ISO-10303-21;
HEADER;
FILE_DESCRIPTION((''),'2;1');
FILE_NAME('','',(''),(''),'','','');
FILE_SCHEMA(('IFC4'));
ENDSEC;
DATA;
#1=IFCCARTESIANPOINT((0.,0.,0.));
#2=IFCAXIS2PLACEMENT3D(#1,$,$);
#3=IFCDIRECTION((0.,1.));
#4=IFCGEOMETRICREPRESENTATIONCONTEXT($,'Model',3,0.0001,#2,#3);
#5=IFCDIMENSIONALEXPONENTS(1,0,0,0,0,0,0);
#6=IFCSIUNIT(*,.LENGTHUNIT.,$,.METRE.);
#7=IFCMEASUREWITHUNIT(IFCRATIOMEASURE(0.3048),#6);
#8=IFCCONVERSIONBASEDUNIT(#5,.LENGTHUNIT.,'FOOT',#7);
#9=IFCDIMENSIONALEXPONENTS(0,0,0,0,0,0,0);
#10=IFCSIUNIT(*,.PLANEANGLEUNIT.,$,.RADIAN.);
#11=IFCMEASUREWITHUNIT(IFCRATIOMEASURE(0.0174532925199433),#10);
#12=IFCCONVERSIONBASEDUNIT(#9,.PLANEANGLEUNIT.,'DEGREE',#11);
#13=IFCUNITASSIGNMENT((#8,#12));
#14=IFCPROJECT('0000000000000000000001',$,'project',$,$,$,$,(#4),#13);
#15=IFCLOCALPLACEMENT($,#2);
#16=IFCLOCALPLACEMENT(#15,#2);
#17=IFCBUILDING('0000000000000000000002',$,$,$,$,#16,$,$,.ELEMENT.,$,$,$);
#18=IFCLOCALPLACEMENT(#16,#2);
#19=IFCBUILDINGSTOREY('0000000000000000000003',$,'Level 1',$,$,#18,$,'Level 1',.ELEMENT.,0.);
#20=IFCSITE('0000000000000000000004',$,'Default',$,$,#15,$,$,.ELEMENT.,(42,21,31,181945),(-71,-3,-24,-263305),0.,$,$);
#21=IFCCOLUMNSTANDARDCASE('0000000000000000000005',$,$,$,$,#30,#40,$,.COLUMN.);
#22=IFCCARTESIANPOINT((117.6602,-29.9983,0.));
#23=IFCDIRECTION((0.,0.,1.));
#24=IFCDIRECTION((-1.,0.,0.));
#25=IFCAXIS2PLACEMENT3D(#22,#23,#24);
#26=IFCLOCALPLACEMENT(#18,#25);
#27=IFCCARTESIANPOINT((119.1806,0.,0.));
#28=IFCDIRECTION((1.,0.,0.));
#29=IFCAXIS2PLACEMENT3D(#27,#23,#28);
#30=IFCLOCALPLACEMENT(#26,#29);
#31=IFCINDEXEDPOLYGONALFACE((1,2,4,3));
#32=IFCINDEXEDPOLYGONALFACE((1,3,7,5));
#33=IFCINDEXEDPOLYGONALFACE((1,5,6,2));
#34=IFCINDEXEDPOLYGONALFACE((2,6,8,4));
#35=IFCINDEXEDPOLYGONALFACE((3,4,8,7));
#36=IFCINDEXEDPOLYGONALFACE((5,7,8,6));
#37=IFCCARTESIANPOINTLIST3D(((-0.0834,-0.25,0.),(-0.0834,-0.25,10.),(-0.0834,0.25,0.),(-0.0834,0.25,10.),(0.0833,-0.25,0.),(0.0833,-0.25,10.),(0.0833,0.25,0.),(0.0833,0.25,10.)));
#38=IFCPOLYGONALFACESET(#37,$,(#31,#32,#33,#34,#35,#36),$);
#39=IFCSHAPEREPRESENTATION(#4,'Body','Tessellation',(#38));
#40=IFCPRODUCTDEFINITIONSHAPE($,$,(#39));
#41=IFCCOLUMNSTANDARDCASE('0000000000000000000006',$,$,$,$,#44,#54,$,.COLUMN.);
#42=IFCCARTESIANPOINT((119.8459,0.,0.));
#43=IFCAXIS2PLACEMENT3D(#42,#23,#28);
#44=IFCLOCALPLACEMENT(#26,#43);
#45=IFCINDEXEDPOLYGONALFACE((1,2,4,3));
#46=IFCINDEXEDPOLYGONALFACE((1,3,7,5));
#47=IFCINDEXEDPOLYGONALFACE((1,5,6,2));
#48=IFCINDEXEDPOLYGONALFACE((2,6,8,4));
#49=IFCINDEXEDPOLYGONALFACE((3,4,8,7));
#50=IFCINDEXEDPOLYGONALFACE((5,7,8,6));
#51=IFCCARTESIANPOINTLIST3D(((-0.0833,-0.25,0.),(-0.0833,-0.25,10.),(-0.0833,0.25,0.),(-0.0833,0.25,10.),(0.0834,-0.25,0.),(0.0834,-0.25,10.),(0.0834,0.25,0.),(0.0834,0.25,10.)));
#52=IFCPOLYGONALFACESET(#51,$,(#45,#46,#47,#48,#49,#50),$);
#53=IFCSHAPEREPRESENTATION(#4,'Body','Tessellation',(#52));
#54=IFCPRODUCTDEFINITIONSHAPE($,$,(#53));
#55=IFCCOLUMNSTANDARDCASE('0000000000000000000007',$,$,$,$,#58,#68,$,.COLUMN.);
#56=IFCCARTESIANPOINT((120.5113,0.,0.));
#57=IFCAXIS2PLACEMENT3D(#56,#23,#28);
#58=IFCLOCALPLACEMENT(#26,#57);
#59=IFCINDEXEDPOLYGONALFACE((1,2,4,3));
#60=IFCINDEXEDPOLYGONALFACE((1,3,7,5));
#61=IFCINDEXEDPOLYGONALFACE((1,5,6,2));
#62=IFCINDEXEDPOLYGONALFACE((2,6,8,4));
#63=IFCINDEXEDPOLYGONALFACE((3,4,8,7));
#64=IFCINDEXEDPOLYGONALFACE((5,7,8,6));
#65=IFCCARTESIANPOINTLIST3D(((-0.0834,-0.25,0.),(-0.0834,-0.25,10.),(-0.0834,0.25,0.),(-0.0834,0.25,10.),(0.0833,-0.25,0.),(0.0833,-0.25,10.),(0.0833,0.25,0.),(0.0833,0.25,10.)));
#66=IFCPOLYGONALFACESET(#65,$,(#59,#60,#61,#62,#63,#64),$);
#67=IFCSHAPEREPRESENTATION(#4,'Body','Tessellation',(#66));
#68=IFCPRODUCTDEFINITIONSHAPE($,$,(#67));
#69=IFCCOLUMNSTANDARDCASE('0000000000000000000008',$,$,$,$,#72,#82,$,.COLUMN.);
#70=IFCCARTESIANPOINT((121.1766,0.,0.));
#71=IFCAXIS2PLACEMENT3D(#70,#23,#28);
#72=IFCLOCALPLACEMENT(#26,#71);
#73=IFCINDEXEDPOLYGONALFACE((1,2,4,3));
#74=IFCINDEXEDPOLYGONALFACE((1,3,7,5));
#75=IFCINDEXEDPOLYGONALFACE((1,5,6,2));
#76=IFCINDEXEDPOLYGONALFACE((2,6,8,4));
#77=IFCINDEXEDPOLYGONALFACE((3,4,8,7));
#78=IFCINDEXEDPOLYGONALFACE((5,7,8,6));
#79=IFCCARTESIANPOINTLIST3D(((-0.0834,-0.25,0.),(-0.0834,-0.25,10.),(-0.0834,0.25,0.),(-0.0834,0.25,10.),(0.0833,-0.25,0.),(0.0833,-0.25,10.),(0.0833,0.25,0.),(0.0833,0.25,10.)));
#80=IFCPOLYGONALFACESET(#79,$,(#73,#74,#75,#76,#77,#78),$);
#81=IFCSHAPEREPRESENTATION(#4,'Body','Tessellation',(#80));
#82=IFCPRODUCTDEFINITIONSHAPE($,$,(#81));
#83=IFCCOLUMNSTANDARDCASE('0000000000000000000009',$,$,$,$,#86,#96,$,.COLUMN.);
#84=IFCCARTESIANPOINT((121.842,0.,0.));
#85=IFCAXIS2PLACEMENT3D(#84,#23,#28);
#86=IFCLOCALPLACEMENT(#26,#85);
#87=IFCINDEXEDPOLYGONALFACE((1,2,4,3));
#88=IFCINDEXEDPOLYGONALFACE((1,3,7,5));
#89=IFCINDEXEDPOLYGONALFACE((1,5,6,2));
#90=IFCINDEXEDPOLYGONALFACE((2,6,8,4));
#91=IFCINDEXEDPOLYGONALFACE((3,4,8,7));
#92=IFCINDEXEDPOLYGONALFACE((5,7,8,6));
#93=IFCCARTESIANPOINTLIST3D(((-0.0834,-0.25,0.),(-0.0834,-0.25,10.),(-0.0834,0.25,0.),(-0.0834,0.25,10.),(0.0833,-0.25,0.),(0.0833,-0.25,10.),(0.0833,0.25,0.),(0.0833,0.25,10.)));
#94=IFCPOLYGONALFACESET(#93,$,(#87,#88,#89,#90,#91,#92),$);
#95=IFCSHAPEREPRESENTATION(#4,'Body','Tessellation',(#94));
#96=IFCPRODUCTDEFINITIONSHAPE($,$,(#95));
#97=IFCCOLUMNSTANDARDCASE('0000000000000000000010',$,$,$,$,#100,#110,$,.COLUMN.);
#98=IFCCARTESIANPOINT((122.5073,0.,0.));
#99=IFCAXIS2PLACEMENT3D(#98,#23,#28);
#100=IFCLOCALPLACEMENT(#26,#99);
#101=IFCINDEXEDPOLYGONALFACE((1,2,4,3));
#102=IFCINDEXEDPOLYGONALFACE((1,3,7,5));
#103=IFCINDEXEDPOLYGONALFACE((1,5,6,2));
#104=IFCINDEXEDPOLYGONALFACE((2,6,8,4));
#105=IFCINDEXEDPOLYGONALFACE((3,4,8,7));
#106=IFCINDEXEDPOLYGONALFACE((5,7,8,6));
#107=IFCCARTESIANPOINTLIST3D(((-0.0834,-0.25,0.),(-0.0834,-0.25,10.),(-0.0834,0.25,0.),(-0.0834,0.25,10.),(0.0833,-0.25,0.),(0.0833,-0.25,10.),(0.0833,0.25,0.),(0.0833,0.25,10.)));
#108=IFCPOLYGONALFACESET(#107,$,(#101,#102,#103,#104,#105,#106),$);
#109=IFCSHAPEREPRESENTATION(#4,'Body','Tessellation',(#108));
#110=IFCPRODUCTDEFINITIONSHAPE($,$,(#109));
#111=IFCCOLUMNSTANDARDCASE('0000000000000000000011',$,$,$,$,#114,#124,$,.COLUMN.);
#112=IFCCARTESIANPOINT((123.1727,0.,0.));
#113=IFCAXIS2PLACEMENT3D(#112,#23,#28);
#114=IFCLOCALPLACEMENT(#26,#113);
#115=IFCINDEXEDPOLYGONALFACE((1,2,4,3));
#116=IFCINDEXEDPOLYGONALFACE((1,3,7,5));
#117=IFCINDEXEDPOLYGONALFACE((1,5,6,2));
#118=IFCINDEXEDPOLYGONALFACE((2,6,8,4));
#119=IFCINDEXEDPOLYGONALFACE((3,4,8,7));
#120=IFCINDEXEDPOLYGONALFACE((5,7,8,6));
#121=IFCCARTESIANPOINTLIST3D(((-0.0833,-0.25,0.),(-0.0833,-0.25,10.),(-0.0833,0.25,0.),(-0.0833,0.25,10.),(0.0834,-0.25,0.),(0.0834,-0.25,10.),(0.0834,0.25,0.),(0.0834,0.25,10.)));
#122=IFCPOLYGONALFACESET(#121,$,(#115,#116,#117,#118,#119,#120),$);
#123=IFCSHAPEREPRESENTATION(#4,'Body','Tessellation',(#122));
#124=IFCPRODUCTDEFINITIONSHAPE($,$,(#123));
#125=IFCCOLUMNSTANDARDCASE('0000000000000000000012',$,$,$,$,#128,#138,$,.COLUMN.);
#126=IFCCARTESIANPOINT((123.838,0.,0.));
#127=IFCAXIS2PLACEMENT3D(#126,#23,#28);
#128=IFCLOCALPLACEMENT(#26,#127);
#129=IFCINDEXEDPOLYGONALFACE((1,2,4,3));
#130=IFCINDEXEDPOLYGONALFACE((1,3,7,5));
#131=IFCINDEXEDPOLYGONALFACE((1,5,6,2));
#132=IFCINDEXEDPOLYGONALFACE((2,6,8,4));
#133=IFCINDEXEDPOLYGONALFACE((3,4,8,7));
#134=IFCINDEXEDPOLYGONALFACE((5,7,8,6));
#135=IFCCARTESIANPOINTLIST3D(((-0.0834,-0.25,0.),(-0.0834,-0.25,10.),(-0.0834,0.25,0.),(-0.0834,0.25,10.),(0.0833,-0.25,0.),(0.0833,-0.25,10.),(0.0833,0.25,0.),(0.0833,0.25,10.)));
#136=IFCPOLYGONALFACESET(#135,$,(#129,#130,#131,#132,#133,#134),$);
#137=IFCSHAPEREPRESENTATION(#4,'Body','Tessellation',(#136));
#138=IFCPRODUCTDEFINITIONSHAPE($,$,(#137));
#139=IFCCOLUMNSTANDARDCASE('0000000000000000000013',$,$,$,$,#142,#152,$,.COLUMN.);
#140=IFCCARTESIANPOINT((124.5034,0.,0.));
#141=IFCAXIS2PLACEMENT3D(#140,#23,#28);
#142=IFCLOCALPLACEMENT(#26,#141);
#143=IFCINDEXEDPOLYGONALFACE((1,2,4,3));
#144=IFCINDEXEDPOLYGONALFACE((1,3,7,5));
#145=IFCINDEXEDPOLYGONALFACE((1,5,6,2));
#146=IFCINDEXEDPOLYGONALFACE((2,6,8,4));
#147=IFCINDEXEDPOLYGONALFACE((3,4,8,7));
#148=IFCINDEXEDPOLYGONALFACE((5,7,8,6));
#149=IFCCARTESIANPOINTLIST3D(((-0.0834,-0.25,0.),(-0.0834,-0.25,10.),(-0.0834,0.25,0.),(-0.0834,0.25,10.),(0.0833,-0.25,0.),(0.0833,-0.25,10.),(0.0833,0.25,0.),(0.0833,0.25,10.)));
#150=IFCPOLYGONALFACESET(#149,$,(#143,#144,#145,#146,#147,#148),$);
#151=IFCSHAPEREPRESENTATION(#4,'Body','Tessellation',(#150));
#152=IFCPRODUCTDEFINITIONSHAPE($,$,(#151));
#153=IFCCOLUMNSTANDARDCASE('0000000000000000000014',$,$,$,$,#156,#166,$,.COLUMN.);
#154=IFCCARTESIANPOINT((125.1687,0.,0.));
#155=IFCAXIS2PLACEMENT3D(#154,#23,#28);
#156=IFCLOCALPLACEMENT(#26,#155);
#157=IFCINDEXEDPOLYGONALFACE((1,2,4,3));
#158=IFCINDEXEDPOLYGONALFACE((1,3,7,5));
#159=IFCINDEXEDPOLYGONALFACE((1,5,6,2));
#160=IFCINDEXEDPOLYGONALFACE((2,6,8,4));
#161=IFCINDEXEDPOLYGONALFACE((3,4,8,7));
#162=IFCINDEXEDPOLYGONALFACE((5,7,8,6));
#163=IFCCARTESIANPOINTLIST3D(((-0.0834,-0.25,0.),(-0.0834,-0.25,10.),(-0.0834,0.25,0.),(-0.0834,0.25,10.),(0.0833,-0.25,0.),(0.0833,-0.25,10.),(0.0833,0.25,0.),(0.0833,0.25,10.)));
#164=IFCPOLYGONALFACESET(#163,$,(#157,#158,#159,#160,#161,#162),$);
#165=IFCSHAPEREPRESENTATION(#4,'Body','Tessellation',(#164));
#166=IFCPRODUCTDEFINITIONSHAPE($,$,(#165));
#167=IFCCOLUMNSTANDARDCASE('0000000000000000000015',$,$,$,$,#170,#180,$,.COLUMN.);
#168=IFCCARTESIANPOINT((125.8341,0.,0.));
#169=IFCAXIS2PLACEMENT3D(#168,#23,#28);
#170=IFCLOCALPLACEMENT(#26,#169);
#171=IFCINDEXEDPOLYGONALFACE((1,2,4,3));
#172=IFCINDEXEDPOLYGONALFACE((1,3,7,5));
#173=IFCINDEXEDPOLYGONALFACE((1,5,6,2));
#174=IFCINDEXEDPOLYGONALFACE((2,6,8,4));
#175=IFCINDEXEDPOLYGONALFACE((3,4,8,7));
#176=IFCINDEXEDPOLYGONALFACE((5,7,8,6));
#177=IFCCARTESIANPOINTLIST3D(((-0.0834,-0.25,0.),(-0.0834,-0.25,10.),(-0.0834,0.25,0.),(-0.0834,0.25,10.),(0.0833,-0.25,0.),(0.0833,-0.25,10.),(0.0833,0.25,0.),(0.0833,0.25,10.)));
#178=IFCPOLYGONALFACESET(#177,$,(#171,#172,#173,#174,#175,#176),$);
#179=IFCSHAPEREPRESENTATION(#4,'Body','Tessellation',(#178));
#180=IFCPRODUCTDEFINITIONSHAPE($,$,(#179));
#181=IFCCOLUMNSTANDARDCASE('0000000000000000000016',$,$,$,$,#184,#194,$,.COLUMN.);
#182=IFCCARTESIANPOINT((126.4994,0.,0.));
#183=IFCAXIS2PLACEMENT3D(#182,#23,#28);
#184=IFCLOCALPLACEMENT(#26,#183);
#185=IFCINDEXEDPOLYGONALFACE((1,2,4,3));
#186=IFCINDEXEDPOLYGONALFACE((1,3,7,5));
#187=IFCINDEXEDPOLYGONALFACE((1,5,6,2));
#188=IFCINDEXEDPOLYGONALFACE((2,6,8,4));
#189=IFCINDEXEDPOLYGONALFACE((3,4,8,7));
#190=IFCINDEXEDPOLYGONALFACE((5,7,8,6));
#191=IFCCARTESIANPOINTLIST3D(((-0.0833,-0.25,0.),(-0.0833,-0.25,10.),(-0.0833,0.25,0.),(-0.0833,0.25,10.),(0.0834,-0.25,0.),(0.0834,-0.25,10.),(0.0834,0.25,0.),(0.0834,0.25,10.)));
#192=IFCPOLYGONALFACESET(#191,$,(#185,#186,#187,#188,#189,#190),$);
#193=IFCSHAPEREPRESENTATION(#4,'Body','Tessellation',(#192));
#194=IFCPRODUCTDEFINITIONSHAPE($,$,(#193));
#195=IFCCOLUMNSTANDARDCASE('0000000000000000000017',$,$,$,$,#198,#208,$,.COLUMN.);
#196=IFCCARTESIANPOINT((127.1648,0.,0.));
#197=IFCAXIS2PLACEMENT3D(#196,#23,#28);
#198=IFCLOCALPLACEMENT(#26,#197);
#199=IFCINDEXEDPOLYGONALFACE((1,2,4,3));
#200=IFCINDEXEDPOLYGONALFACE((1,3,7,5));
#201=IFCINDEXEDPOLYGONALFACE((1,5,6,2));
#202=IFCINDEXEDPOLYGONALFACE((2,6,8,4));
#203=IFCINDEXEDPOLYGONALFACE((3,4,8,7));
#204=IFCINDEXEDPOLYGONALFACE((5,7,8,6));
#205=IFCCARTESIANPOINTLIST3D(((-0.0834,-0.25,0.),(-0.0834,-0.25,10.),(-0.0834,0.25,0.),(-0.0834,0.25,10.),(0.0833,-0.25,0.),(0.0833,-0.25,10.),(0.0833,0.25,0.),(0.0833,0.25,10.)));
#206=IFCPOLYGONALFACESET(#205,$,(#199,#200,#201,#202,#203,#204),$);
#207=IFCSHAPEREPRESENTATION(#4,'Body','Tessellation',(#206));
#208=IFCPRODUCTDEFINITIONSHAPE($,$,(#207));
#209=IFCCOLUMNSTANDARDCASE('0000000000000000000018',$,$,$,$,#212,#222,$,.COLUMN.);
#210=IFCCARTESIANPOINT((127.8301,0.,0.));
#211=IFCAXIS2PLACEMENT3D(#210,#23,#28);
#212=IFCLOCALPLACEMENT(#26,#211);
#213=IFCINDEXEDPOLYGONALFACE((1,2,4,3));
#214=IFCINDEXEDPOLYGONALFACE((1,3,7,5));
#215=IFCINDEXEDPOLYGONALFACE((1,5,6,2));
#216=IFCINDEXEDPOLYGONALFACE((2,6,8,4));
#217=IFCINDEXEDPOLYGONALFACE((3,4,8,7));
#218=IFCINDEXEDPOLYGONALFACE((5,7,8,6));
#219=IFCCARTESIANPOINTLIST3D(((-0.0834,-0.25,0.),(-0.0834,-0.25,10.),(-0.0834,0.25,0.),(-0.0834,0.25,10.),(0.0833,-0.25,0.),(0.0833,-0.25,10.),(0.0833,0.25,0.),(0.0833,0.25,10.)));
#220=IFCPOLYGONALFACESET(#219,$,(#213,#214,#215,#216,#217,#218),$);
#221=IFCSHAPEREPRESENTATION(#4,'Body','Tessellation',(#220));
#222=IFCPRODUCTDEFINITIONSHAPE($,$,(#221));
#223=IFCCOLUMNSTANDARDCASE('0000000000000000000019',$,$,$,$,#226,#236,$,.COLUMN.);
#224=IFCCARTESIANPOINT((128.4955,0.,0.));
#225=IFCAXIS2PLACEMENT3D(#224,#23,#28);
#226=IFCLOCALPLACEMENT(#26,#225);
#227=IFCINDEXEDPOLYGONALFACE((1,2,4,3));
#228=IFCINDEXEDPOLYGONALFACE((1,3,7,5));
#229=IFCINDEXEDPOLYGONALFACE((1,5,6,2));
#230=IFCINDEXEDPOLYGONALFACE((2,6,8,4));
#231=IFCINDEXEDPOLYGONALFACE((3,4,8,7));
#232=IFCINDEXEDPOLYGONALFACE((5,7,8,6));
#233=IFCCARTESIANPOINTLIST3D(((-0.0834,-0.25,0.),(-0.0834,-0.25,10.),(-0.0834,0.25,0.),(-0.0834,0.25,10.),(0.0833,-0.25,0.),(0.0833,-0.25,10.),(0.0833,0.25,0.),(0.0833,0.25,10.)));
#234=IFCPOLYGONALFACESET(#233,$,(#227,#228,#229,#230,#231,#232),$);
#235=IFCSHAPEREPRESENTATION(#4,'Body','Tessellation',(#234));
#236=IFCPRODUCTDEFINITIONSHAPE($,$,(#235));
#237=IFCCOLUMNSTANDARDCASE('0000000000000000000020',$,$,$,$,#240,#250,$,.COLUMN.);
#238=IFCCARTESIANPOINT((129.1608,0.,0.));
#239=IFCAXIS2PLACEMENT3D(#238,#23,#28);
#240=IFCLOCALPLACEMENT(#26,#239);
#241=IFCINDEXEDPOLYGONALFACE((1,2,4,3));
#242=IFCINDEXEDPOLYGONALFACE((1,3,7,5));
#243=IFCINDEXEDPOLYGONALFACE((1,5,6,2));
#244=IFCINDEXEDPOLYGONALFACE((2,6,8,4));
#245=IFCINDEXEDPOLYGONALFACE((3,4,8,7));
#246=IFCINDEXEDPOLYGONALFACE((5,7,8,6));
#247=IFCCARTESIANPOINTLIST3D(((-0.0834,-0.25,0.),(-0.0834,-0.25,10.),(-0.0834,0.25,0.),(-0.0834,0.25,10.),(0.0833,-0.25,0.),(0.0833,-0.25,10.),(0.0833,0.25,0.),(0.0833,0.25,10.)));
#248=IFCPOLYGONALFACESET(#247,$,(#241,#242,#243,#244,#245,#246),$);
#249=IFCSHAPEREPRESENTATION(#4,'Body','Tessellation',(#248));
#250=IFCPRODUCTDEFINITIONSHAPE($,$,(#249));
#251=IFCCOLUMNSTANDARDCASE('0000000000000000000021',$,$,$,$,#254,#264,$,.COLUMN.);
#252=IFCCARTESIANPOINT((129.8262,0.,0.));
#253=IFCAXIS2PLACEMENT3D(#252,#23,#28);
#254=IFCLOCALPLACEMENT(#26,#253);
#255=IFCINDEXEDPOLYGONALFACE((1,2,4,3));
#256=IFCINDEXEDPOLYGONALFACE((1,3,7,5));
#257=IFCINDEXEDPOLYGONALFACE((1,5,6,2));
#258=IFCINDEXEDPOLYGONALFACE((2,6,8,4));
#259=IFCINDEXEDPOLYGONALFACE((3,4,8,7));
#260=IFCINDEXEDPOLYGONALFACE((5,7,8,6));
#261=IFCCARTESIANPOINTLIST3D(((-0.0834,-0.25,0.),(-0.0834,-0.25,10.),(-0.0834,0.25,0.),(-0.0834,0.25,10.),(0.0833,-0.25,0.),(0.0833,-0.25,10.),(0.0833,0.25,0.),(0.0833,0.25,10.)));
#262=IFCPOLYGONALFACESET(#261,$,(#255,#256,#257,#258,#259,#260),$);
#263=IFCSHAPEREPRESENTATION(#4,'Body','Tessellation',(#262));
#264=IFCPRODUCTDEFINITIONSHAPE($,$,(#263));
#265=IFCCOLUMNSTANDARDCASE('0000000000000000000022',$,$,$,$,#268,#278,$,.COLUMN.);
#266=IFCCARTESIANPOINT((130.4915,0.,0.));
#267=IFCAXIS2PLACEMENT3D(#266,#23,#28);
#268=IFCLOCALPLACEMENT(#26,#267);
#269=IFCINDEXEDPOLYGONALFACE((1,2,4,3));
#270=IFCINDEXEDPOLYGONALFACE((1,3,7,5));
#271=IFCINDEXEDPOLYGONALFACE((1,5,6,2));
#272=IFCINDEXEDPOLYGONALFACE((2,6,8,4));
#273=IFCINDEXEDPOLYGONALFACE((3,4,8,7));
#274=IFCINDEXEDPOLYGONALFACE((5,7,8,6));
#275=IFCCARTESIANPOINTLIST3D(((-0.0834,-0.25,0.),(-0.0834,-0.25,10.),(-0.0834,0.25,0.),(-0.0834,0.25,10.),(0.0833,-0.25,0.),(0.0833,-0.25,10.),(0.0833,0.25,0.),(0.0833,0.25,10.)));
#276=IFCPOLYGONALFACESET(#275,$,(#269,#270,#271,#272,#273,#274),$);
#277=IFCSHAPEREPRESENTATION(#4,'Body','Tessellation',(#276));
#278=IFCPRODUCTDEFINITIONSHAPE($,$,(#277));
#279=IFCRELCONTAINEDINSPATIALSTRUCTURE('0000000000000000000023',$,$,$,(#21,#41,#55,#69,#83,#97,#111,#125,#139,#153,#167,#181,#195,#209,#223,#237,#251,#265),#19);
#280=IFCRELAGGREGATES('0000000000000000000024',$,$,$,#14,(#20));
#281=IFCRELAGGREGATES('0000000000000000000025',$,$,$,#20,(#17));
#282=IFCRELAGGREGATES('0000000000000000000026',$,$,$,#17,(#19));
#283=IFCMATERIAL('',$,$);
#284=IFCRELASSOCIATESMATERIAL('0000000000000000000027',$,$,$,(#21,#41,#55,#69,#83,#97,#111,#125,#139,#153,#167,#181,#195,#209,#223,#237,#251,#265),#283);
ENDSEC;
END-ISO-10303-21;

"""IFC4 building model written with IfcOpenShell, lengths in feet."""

from ifc_helpers import new_model, entity, si_unit, converted_unit, direction, frame, origin, place, context, project, spatial, rectangle, extrude, material, element, save


model = new_model("IFC4")

# Units and contexts
model_context = context("Model", 3, precision=0.0001, world=origin(), true_north=direction((0.0, 1.0)))
ifc_project = project(units=[converted_unit("LENGTHUNIT", "FOOT", entity("IfcRatioMeasure", 0.3048), si_unit("LENGTHUNIT", "METRE"), dimensions=[1, 0, 0, 0, 0, 0, 0]), converted_unit("PLANEANGLEUNIT", "DEGREE", entity("IfcRatioMeasure", 0.0174532925199433), si_unit("PLANEANGLEUNIT", "RADIAN"), dimensions=[0, 0, 0, 0, 0, 0, 0])], contexts=[model_context])

# Site, building, storey
site_placement = place(None, origin())
site = spatial("IfcSite", under=ifc_project, at=site_placement, Name="Default", CompositionType="ELEMENT", RefLatitude=(42, 21, 31, 181945), RefLongitude=(-71, -3, -24, -263305), RefElevation=0.0)
building_placement = place(site_placement, origin())
building = spatial("IfcBuilding", under=site, at=building_placement, CompositionType="ELEMENT")
storey_placement = place(building_placement, origin())
storey = spatial("IfcBuildingStorey", under=building, at=storey_placement, Name="Level 1", LongName="Level 1", CompositionType="ELEMENT", Elevation=0.0)

# Columns
ifc_material = material(Name="")
placement = place(storey_placement, frame((117.6602, -29.9983, 0.0), z_axis=(0.0, 0.0, 1.0), x_axis=(-1.0, 0.0, 0.0)))
for number, where, z_axis, x_axis in (
    (1, (119.1806, 0.0, 0.0), (0.0, 0.0, 1.0), (1.0, 0.0, 0.0)),
    (2, (119.8459, 0.0, 0.0), (0.0, 0.0, 1.0), (1.0, 0.0, 0.0)),
    (3, (120.5113, 0.0, 0.0), (0.0, 0.0, 1.0), (1.0, 0.0, 0.0)),
    (4, (121.1766, 0.0, 0.0), (0.0, 0.0, 1.0), (1.0, 0.0, 0.0)),
    (5, (121.842, 0.0, 0.0), (0.0, 0.0, 1.0), (1.0, 0.0, 0.0)),
    (6, (122.5073, 0.0, 0.0), (0.0, 0.0, 1.0), (1.0, 0.0, 0.0)),
    (7, (123.1727, 0.0, 0.0), (0.0, 0.0, 1.0), (1.0, 0.0, 0.0)),
    (8, (123.838, 0.0, 0.0), (0.0, 0.0, 1.0), (1.0, 0.0, 0.0)),
    (9, (124.5034, 0.0, 0.0), (0.0, 0.0, 1.0), (1.0, 0.0, 0.0)),
    (10, (125.1687, 0.0, 0.0), (0.0, 0.0, 1.0), (1.0, 0.0, 0.0)),
    (11, (125.8341, 0.0, 0.0), (0.0, 0.0, 1.0), (1.0, 0.0, 0.0)),
    (12, (126.4994, 0.0, 0.0), (0.0, 0.0, 1.0), (1.0, 0.0, 0.0)),
    (13, (127.1648, 0.0, 0.0), (0.0, 0.0, 1.0), (1.0, 0.0, 0.0)),
    (14, (127.8301, 0.0, 0.0), (0.0, 0.0, 1.0), (1.0, 0.0, 0.0)),
    (15, (128.4955, 0.0, 0.0), (0.0, 0.0, 1.0), (1.0, 0.0, 0.0)),
    (16, (129.1608, 0.0, 0.0), (0.0, 0.0, 1.0), (1.0, 0.0, 0.0)),
    (17, (129.8262, 0.0, 0.0), (0.0, 0.0, 1.0), (1.0, 0.0, 0.0)),
    (18, (130.4915, 0.0, 0.0), (0.0, 0.0, 1.0), (1.0, 0.0, 0.0)),
):
    element("IfcColumnStandardCase", number, at=place(placement, frame(where, z_axis=z_axis, x_axis=x_axis)), inside=storey, material=ifc_material, PredefinedType="COLUMN", context=model_context, shape_type="SweptSolid", body=[
        extrude(rectangle(XDim=0.1667, YDim=0.5), origin(), (0.0, 0.0, 1.0), 10.0),
    ])

save(model, "model.ifc")
